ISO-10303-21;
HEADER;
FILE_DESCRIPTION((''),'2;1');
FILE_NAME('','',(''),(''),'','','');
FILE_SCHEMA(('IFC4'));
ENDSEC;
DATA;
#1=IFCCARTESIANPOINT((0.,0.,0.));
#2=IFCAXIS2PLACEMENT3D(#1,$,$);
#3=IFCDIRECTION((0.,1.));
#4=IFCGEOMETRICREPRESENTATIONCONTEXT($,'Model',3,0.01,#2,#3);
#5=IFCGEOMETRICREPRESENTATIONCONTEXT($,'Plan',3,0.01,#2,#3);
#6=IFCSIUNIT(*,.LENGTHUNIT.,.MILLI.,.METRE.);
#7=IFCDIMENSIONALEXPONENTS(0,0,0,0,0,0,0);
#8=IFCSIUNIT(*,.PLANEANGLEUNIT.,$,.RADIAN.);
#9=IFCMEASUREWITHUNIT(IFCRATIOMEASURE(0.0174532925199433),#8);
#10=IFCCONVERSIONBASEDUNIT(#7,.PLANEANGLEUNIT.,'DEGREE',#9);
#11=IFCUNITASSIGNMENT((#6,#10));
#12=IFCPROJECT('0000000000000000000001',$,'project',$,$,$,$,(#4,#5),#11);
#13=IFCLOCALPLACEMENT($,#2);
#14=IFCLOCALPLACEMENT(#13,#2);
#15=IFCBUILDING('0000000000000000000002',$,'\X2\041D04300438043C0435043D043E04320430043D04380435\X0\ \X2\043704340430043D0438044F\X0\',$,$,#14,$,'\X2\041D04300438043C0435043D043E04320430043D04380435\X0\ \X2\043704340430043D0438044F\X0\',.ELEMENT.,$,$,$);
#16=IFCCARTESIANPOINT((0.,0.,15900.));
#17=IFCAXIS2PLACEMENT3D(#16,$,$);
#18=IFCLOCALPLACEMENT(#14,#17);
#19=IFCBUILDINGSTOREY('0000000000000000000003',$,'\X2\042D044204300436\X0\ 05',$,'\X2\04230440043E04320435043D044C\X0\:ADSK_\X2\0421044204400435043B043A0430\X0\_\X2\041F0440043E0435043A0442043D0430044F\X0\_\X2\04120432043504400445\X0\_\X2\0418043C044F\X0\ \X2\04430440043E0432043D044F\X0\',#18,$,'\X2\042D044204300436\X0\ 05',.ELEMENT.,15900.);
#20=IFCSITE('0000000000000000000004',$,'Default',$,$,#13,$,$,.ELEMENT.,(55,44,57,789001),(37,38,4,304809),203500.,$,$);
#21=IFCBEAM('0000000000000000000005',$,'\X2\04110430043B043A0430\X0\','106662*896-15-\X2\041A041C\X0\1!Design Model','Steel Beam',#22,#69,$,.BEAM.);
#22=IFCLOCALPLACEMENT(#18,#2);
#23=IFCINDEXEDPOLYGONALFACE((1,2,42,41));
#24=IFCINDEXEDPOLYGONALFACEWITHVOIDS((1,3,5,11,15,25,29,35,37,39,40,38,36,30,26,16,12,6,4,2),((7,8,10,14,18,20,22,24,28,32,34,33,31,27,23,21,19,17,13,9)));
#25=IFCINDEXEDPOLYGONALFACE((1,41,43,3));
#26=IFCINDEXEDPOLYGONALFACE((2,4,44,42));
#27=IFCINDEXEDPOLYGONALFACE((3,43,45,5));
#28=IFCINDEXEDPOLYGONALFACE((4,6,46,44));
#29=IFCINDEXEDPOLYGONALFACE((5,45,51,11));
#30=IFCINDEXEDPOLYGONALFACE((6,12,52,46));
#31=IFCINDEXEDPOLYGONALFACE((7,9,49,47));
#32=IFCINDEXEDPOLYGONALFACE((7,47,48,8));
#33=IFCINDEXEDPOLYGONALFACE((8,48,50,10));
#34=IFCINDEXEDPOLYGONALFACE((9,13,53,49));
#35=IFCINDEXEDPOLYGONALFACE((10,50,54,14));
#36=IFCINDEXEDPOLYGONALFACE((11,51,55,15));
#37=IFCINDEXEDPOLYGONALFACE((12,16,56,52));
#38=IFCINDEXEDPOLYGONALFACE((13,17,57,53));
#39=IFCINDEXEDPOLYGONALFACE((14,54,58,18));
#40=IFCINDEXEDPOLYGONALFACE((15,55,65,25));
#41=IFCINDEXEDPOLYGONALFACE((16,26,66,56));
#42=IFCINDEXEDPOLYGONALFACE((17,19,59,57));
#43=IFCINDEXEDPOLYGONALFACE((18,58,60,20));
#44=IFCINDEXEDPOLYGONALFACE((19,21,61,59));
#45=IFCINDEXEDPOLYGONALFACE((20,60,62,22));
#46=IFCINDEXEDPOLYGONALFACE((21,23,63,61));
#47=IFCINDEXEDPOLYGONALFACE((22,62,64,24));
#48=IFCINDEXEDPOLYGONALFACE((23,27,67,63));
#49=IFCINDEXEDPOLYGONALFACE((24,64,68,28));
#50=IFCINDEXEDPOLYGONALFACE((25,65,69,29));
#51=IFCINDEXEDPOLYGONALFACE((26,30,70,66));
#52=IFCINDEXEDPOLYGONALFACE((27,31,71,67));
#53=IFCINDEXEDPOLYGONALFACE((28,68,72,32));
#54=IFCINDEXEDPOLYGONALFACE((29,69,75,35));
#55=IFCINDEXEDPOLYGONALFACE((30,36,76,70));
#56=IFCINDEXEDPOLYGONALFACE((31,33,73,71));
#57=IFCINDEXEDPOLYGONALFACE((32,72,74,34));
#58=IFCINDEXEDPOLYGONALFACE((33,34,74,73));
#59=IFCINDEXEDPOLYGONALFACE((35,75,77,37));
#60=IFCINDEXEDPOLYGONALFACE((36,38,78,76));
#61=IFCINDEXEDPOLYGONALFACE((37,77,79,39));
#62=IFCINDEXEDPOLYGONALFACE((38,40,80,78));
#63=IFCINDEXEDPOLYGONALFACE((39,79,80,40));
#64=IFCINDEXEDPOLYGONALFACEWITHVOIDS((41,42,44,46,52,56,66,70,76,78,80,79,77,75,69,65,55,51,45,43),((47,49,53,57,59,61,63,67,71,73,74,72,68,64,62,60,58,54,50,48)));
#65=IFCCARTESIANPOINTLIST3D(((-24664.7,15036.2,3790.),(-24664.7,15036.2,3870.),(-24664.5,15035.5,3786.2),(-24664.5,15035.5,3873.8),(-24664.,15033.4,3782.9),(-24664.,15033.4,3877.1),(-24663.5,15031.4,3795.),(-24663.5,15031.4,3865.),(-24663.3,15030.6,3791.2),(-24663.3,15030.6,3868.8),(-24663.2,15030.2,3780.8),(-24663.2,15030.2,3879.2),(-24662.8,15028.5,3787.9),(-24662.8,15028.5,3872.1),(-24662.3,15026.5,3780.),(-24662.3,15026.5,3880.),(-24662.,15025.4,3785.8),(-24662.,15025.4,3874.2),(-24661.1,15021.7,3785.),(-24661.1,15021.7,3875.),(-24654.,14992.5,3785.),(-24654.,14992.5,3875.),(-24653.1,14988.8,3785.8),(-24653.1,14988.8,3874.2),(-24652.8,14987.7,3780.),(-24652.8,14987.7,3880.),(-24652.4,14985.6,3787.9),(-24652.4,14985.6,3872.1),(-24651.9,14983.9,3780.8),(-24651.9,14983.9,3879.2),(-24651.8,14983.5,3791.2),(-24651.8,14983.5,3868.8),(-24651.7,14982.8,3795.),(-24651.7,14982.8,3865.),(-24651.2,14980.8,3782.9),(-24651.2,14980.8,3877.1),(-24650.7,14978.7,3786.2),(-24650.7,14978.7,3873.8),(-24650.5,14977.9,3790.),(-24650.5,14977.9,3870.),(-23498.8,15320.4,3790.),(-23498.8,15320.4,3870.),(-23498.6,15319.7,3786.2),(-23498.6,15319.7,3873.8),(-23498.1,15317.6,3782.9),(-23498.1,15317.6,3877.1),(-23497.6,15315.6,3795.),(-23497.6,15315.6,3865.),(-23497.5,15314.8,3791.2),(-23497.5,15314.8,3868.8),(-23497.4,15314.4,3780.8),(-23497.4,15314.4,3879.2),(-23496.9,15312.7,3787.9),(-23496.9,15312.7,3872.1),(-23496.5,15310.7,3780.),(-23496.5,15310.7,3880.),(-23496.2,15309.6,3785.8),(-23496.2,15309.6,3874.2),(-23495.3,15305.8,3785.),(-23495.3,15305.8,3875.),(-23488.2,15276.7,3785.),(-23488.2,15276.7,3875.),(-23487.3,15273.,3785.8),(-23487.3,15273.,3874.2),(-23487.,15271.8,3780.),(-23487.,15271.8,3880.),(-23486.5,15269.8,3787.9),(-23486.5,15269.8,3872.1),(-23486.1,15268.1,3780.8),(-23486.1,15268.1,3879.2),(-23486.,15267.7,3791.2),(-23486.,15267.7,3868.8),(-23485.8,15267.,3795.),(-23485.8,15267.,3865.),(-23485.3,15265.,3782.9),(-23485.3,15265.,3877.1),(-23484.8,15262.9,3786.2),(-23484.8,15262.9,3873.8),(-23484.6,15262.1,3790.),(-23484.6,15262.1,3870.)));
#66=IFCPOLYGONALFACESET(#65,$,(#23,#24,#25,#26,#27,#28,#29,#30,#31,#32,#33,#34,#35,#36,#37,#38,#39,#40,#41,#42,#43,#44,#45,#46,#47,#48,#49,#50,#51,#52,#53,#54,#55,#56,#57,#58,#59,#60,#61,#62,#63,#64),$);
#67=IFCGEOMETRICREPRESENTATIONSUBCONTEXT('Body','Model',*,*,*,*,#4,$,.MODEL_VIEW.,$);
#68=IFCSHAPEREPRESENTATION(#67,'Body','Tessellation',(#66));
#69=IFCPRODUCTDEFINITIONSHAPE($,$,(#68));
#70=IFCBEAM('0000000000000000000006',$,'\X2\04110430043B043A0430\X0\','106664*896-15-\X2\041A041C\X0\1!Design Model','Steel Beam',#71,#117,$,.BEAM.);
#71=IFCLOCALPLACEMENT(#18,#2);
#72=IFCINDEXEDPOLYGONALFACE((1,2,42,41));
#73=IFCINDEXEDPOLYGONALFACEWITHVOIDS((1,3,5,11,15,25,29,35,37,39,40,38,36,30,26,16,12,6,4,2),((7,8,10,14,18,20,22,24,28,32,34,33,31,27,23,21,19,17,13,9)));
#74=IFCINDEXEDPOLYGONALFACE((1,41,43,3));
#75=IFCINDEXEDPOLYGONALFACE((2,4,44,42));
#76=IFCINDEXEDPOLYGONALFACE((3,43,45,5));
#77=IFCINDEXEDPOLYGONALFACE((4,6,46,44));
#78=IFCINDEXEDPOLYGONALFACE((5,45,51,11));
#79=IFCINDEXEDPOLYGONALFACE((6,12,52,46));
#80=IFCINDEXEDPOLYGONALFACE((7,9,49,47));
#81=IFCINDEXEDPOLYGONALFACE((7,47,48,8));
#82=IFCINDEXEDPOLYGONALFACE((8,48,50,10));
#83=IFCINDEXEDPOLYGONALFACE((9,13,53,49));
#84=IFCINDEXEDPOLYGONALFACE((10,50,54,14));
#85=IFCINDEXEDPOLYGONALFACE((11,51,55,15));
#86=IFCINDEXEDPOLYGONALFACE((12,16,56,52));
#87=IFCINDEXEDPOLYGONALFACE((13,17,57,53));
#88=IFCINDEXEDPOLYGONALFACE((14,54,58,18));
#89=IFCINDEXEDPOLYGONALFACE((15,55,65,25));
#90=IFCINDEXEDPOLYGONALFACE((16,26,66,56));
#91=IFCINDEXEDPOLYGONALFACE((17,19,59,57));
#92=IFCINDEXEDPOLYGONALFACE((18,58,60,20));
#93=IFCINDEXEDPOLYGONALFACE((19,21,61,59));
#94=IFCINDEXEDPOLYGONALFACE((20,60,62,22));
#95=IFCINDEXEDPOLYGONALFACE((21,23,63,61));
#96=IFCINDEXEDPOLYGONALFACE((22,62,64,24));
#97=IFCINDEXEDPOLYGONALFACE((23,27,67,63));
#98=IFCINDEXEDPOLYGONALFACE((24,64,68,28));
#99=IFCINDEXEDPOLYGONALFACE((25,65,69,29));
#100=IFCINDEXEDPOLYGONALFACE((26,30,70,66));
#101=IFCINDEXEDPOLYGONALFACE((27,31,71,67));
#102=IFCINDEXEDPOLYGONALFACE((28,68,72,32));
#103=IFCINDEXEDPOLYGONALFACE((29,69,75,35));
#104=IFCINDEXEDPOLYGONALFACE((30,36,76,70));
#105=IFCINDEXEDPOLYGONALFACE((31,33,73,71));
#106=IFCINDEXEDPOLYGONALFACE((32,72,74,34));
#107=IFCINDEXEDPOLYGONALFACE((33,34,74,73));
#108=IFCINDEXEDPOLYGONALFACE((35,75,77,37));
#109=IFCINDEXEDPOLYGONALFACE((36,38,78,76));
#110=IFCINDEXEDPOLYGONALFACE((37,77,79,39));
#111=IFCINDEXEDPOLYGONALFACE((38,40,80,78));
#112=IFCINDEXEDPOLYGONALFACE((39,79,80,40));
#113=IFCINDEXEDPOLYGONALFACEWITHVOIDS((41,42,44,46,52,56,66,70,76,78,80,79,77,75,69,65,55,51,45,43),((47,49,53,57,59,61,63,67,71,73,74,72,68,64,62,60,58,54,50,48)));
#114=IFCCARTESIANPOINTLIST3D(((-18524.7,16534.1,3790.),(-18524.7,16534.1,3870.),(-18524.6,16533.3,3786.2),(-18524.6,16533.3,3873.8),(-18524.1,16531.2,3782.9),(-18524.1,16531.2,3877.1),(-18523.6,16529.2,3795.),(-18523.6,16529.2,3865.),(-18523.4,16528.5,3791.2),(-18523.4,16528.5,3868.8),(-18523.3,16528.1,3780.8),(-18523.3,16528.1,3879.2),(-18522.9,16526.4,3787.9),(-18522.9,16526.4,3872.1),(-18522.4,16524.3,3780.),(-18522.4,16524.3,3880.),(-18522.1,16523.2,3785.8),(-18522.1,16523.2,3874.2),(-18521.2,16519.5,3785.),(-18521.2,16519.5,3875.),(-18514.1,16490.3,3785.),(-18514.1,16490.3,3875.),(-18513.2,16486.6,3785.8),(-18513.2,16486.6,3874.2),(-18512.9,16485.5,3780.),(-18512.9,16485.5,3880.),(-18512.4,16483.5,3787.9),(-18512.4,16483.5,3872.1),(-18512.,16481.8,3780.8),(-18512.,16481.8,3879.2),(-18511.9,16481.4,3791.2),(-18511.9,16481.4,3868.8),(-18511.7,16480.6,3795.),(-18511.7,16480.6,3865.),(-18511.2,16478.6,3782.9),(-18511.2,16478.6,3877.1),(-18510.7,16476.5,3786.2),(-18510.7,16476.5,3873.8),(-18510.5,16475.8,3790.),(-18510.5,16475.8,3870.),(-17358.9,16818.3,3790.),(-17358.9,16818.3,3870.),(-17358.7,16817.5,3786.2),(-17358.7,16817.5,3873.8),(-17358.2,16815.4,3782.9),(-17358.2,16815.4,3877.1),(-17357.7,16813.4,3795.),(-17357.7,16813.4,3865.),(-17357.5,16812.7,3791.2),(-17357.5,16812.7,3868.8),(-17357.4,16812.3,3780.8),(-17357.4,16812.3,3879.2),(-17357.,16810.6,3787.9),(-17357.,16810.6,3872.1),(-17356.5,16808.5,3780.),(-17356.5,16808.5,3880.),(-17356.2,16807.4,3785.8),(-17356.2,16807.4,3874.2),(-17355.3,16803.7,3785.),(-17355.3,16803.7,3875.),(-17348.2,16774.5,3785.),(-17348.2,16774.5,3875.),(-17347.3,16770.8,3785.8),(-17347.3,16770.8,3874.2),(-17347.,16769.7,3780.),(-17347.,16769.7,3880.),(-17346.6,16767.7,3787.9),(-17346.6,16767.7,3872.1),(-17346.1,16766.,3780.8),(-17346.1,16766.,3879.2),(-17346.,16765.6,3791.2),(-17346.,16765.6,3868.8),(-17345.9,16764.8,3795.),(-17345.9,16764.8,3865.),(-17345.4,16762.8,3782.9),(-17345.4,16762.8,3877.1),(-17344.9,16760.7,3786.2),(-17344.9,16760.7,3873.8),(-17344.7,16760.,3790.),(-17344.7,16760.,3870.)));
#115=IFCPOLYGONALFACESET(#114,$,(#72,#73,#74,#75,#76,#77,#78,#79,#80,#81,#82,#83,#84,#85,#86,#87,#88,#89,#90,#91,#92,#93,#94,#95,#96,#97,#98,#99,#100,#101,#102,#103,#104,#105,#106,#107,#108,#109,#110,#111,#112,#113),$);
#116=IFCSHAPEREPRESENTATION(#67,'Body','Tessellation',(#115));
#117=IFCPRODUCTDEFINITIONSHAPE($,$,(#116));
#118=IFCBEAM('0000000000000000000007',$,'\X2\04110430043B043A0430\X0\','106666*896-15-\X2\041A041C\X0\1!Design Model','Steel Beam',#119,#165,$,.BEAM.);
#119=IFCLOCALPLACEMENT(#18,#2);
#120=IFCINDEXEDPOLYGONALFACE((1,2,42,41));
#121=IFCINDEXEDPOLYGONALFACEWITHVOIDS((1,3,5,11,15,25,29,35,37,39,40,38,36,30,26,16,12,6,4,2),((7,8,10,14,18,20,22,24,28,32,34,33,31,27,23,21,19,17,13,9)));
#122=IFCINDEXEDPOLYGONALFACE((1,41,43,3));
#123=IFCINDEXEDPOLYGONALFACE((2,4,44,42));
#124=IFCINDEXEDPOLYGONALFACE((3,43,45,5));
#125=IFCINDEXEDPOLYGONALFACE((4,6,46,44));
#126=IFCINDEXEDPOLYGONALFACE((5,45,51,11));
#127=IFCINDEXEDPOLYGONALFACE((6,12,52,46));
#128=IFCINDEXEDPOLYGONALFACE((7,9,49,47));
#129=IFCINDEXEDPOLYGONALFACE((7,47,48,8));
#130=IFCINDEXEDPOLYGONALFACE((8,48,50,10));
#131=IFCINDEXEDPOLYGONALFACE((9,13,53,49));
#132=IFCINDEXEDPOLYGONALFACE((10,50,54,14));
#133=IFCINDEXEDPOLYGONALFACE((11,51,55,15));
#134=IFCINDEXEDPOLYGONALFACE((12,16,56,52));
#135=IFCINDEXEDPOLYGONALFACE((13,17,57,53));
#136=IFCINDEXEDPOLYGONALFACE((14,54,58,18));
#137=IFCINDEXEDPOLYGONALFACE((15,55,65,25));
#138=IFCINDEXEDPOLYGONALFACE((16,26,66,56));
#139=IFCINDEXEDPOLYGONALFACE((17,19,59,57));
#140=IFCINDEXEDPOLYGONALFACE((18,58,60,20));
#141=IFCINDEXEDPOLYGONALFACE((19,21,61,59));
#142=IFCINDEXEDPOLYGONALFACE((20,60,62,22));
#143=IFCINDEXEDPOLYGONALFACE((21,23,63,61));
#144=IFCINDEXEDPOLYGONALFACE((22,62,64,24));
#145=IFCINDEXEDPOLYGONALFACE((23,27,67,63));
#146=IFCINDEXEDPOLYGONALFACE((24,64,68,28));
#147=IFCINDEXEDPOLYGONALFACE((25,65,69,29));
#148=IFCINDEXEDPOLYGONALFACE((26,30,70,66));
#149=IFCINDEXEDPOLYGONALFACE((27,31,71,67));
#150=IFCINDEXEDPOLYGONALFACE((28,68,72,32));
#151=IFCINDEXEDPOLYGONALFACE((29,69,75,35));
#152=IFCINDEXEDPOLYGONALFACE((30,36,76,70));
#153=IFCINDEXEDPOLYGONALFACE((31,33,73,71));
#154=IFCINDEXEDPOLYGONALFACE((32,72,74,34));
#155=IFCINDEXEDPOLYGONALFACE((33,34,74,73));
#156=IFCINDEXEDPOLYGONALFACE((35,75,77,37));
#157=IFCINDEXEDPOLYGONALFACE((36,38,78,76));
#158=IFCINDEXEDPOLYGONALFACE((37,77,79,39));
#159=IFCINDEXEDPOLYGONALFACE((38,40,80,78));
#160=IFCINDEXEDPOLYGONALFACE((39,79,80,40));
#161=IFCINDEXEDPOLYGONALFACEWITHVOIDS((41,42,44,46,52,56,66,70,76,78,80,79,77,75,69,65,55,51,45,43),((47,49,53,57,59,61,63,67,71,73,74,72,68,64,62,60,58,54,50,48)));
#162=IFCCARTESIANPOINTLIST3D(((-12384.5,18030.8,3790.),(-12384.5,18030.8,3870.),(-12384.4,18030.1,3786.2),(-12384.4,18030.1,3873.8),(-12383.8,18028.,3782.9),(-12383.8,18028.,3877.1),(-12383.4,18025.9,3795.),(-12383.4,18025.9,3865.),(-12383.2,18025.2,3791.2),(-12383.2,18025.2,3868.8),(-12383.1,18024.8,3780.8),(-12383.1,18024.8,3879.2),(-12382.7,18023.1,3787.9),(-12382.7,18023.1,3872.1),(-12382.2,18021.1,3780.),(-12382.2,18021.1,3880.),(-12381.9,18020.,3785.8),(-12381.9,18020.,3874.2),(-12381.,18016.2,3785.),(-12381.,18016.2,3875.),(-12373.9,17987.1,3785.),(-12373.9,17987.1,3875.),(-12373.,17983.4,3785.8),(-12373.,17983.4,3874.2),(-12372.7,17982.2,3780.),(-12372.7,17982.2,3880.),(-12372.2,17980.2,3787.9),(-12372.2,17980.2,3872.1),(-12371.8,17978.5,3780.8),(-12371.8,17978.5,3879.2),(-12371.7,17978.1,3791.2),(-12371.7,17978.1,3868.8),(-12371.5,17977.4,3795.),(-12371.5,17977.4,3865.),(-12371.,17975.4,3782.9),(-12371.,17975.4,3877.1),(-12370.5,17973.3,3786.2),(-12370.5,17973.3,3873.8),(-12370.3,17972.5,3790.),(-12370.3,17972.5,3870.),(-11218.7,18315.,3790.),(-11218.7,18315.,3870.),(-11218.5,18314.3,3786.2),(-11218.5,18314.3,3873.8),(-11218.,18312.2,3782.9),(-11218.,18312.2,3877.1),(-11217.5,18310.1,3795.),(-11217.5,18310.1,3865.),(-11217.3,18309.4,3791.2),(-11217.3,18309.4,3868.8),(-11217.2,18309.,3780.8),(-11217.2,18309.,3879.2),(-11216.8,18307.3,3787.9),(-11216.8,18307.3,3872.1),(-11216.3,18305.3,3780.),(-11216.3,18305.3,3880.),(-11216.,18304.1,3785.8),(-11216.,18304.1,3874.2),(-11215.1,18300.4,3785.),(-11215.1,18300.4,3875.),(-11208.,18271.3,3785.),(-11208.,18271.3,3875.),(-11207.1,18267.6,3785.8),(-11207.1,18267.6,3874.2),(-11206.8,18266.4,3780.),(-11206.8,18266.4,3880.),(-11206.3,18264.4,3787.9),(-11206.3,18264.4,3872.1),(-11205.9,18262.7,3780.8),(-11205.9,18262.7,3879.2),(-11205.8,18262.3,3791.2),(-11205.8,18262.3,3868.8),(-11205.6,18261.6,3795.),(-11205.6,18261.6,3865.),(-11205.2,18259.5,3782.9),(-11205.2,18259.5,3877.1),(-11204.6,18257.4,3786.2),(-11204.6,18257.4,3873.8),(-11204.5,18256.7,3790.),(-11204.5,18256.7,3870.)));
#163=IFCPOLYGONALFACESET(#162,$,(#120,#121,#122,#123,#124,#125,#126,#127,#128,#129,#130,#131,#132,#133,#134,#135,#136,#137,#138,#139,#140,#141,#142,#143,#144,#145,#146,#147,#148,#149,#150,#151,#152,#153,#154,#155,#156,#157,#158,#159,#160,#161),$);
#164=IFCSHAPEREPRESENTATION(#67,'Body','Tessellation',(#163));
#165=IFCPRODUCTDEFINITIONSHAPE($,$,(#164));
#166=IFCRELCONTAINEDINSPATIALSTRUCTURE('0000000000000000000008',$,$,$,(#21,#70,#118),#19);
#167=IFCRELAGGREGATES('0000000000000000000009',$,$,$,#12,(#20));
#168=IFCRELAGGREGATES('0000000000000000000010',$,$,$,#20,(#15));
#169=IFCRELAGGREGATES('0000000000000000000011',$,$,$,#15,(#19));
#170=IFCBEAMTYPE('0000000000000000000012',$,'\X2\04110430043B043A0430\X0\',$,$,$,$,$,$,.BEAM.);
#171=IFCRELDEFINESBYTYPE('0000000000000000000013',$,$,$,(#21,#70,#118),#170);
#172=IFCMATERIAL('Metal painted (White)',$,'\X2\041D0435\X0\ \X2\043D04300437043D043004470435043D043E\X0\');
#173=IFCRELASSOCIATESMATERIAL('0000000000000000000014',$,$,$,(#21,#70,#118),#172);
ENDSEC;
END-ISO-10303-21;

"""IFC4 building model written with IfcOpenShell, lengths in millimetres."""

from ifc_helpers import new_model, entity, si_unit, converted_unit, direction, frame, origin, place, context, subcontext, project, spatial, indexed_curve, outline, extrude, material, type_object, element, save


model = new_model("IFC4")

# Units and contexts
model_context = context("Model", 3, precision=0.01, world=origin(), true_north=direction((0.0, 1.0)))
plan_context = context("Plan", 3, precision=0.01, world=origin(), true_north=direction((0.0, 1.0)))
body_context = subcontext(model_context, "Body", "Model", "MODEL_VIEW")
ifc_project = project(units=[si_unit("LENGTHUNIT", "METRE", prefix="MILLI"), converted_unit("PLANEANGLEUNIT", "DEGREE", entity("IfcRatioMeasure", 0.0174532925199433), si_unit("PLANEANGLEUNIT", "RADIAN"), dimensions=[0, 0, 0, 0, 0, 0, 0])], contexts=[model_context, plan_context])

# Site, building, storey
site_placement = place(None, origin())
site = spatial("IfcSite", under=ifc_project, at=site_placement, Name="Default", CompositionType="ELEMENT", RefLatitude=(55, 44, 57, 789001), RefLongitude=(37, 38, 4, 304809), RefElevation=203500.0)
building_placement = place(site_placement, origin())
building = spatial("IfcBuilding", under=site, at=building_placement, Name="Наименование здания", LongName="Наименование здания", CompositionType="ELEMENT")
storey_placement = place(building_placement, frame((0.0, 0.0, 15900.0)))
storey = spatial("IfcBuildingStorey", under=building, at=storey_placement, Name="Этаж 05", ObjectType="Уровень:ADSK_Стрелка_Проектная_Вверх_Имя уровня", LongName="Этаж 05", CompositionType="ELEMENT", Elevation=15900.0)

# Beams
ifc_material = material(Name="Metal painted (White)", Category="Не назначено")
beam_type = type_object("IfcBeamType", Name="Балка", PredefinedType="BEAM")
beam_1_placement = place(storey_placement, origin())
element("IfcBeam", 1, at=beam_1_placement, inside=storey, type_object=beam_type, material=ifc_material, Name="Балка", Description="106662*896-15-КМ1!Design Model", ObjectType="Steel Beam", PredefinedType="BEAM", context=body_context, shape_type="SweptSolid", body=[
    extrude(outline(indexed_curve([(9.9, -52.9), (13.8, -52.9), (17.4, -51.4), (20.1, -48.7), (21.6, -45.1), (37.2, 33.4), (37.2, 37.3), (35.7, 40.9), (33.0, 43.6), (29.4, 45.1), (-9.9, 52.9), (-13.8, 52.9), (-17.4, 51.4), (-20.1, 48.7), (-21.6, 45.1), (-37.2, -33.4), (-37.2, -37.3), (-35.7, -40.9), (-33.0, -43.6), (-29.4, -45.1), (9.9, -52.9)], self_intersect=False), holes=[indexed_curve([(-31.3, -29.5), (-17.7, 39.2), (-16.2, 42.8), (-13.4, 45.6), (-9.8, 47.1), (-5.9, 47.1), (23.5, 41.2), (27.1, 39.7), (29.9, 37.0), (31.3, 33.4), (31.3, 29.5), (17.7, -39.2), (16.2, -42.8), (13.4, -45.6), (9.8, -47.1), (5.9, -47.1), (-23.5, -41.2), (-27.1, -39.7), (-29.9, -37.0), (-31.3, -33.4), (-31.3, -29.5)], self_intersect=False)]), frame((-24657.6, 15007.1, 3830.0), z_axis=(0.971552, 0.236826, 0.0), x_axis=(-0.232276, 0.952884, 0.19509)), (0.0, 0.0, 1.0), 1200.0),
])
beam_2_placement = place(storey_placement, origin())
element("IfcBeam", 2, at=beam_2_placement, inside=storey, type_object=beam_type, material=ifc_material, Name="Балка", Description="106664*896-15-КМ1!Design Model", ObjectType="Steel Beam", PredefinedType="BEAM", context=body_context, shape_type="SweptSolid", body=[
    extrude(outline(indexed_curve([(9.9, -52.9), (13.8, -52.9), (17.4, -51.4), (20.1, -48.7), (21.6, -45.1), (37.2, 33.4), (37.2, 37.3), (35.7, 40.9), (33.0, 43.6), (29.4, 45.1), (-9.9, 52.9), (-13.8, 52.9), (-17.4, 51.4), (-20.1, 48.7), (-21.6, 45.1), (-37.2, -33.4), (-37.2, -37.3), (-35.7, -40.9), (-33.0, -43.6), (-29.4, -45.1), (9.9, -52.9)], self_intersect=False), holes=[indexed_curve([(-31.3, -29.5), (-17.7, 39.2), (-16.2, 42.8), (-13.4, 45.6), (-9.8, 47.1), (-5.9, 47.1), (23.5, 41.2), (27.1, 39.7), (29.9, 37.0), (31.3, 33.4), (31.3, 29.5), (17.7, -39.2), (16.2, -42.8), (13.4, -45.6), (9.8, -47.1), (5.9, -47.1), (-23.5, -41.2), (-27.1, -39.7), (-29.9, -37.0), (-31.3, -33.4), (-31.3, -29.5)], self_intersect=False)]), frame((-18517.6, 16504.9, 3830.0), z_axis=(0.971552, 0.236826, 0.0), x_axis=(-0.232276, 0.952884, 0.19509)), (0.0, 0.0, 1.0), 1200.0),
])
beam_3_placement = place(storey_placement, origin())
element("IfcBeam", 3, at=beam_3_placement, inside=storey, type_object=beam_type, material=ifc_material, Name="Балка", Description="106666*896-15-КМ1!Design Model", ObjectType="Steel Beam", PredefinedType="BEAM", context=body_context, shape_type="SweptSolid", body=[
    extrude(outline(indexed_curve([(9.9, -52.9), (13.8, -52.9), (17.4, -51.4), (20.1, -48.7), (21.6, -45.1), (37.2, 33.4), (37.2, 37.3), (35.7, 40.9), (33.0, 43.6), (29.4, 45.1), (-9.9, 52.9), (-13.8, 52.9), (-17.4, 51.4), (-20.1, 48.7), (-21.6, 45.1), (-37.2, -33.4), (-37.2, -37.3), (-35.7, -40.9), (-33.0, -43.6), (-29.4, -45.1), (9.9, -52.9)], self_intersect=False), holes=[indexed_curve([(-31.3, -29.5), (-17.7, 39.2), (-16.2, 42.8), (-13.4, 45.6), (-9.8, 47.1), (-5.9, 47.1), (23.5, 41.2), (27.1, 39.7), (29.9, 37.0), (31.3, 33.4), (31.3, 29.5), (17.7, -39.2), (16.2, -42.8), (13.4, -45.6), (9.8, -47.1), (5.9, -47.1), (-23.5, -41.2), (-27.1, -39.7), (-29.9, -37.0), (-31.3, -33.4), (-31.3, -29.5)], self_intersect=False)]), frame((-12377.4, 18001.7, 3830.0), z_axis=(0.971552, 0.236826, 0.0), x_axis=(-0.232276, 0.952884, 0.19509)), (0.0, 0.0, 1.0), 1200.0),
])

save(model, "model.ifc")
